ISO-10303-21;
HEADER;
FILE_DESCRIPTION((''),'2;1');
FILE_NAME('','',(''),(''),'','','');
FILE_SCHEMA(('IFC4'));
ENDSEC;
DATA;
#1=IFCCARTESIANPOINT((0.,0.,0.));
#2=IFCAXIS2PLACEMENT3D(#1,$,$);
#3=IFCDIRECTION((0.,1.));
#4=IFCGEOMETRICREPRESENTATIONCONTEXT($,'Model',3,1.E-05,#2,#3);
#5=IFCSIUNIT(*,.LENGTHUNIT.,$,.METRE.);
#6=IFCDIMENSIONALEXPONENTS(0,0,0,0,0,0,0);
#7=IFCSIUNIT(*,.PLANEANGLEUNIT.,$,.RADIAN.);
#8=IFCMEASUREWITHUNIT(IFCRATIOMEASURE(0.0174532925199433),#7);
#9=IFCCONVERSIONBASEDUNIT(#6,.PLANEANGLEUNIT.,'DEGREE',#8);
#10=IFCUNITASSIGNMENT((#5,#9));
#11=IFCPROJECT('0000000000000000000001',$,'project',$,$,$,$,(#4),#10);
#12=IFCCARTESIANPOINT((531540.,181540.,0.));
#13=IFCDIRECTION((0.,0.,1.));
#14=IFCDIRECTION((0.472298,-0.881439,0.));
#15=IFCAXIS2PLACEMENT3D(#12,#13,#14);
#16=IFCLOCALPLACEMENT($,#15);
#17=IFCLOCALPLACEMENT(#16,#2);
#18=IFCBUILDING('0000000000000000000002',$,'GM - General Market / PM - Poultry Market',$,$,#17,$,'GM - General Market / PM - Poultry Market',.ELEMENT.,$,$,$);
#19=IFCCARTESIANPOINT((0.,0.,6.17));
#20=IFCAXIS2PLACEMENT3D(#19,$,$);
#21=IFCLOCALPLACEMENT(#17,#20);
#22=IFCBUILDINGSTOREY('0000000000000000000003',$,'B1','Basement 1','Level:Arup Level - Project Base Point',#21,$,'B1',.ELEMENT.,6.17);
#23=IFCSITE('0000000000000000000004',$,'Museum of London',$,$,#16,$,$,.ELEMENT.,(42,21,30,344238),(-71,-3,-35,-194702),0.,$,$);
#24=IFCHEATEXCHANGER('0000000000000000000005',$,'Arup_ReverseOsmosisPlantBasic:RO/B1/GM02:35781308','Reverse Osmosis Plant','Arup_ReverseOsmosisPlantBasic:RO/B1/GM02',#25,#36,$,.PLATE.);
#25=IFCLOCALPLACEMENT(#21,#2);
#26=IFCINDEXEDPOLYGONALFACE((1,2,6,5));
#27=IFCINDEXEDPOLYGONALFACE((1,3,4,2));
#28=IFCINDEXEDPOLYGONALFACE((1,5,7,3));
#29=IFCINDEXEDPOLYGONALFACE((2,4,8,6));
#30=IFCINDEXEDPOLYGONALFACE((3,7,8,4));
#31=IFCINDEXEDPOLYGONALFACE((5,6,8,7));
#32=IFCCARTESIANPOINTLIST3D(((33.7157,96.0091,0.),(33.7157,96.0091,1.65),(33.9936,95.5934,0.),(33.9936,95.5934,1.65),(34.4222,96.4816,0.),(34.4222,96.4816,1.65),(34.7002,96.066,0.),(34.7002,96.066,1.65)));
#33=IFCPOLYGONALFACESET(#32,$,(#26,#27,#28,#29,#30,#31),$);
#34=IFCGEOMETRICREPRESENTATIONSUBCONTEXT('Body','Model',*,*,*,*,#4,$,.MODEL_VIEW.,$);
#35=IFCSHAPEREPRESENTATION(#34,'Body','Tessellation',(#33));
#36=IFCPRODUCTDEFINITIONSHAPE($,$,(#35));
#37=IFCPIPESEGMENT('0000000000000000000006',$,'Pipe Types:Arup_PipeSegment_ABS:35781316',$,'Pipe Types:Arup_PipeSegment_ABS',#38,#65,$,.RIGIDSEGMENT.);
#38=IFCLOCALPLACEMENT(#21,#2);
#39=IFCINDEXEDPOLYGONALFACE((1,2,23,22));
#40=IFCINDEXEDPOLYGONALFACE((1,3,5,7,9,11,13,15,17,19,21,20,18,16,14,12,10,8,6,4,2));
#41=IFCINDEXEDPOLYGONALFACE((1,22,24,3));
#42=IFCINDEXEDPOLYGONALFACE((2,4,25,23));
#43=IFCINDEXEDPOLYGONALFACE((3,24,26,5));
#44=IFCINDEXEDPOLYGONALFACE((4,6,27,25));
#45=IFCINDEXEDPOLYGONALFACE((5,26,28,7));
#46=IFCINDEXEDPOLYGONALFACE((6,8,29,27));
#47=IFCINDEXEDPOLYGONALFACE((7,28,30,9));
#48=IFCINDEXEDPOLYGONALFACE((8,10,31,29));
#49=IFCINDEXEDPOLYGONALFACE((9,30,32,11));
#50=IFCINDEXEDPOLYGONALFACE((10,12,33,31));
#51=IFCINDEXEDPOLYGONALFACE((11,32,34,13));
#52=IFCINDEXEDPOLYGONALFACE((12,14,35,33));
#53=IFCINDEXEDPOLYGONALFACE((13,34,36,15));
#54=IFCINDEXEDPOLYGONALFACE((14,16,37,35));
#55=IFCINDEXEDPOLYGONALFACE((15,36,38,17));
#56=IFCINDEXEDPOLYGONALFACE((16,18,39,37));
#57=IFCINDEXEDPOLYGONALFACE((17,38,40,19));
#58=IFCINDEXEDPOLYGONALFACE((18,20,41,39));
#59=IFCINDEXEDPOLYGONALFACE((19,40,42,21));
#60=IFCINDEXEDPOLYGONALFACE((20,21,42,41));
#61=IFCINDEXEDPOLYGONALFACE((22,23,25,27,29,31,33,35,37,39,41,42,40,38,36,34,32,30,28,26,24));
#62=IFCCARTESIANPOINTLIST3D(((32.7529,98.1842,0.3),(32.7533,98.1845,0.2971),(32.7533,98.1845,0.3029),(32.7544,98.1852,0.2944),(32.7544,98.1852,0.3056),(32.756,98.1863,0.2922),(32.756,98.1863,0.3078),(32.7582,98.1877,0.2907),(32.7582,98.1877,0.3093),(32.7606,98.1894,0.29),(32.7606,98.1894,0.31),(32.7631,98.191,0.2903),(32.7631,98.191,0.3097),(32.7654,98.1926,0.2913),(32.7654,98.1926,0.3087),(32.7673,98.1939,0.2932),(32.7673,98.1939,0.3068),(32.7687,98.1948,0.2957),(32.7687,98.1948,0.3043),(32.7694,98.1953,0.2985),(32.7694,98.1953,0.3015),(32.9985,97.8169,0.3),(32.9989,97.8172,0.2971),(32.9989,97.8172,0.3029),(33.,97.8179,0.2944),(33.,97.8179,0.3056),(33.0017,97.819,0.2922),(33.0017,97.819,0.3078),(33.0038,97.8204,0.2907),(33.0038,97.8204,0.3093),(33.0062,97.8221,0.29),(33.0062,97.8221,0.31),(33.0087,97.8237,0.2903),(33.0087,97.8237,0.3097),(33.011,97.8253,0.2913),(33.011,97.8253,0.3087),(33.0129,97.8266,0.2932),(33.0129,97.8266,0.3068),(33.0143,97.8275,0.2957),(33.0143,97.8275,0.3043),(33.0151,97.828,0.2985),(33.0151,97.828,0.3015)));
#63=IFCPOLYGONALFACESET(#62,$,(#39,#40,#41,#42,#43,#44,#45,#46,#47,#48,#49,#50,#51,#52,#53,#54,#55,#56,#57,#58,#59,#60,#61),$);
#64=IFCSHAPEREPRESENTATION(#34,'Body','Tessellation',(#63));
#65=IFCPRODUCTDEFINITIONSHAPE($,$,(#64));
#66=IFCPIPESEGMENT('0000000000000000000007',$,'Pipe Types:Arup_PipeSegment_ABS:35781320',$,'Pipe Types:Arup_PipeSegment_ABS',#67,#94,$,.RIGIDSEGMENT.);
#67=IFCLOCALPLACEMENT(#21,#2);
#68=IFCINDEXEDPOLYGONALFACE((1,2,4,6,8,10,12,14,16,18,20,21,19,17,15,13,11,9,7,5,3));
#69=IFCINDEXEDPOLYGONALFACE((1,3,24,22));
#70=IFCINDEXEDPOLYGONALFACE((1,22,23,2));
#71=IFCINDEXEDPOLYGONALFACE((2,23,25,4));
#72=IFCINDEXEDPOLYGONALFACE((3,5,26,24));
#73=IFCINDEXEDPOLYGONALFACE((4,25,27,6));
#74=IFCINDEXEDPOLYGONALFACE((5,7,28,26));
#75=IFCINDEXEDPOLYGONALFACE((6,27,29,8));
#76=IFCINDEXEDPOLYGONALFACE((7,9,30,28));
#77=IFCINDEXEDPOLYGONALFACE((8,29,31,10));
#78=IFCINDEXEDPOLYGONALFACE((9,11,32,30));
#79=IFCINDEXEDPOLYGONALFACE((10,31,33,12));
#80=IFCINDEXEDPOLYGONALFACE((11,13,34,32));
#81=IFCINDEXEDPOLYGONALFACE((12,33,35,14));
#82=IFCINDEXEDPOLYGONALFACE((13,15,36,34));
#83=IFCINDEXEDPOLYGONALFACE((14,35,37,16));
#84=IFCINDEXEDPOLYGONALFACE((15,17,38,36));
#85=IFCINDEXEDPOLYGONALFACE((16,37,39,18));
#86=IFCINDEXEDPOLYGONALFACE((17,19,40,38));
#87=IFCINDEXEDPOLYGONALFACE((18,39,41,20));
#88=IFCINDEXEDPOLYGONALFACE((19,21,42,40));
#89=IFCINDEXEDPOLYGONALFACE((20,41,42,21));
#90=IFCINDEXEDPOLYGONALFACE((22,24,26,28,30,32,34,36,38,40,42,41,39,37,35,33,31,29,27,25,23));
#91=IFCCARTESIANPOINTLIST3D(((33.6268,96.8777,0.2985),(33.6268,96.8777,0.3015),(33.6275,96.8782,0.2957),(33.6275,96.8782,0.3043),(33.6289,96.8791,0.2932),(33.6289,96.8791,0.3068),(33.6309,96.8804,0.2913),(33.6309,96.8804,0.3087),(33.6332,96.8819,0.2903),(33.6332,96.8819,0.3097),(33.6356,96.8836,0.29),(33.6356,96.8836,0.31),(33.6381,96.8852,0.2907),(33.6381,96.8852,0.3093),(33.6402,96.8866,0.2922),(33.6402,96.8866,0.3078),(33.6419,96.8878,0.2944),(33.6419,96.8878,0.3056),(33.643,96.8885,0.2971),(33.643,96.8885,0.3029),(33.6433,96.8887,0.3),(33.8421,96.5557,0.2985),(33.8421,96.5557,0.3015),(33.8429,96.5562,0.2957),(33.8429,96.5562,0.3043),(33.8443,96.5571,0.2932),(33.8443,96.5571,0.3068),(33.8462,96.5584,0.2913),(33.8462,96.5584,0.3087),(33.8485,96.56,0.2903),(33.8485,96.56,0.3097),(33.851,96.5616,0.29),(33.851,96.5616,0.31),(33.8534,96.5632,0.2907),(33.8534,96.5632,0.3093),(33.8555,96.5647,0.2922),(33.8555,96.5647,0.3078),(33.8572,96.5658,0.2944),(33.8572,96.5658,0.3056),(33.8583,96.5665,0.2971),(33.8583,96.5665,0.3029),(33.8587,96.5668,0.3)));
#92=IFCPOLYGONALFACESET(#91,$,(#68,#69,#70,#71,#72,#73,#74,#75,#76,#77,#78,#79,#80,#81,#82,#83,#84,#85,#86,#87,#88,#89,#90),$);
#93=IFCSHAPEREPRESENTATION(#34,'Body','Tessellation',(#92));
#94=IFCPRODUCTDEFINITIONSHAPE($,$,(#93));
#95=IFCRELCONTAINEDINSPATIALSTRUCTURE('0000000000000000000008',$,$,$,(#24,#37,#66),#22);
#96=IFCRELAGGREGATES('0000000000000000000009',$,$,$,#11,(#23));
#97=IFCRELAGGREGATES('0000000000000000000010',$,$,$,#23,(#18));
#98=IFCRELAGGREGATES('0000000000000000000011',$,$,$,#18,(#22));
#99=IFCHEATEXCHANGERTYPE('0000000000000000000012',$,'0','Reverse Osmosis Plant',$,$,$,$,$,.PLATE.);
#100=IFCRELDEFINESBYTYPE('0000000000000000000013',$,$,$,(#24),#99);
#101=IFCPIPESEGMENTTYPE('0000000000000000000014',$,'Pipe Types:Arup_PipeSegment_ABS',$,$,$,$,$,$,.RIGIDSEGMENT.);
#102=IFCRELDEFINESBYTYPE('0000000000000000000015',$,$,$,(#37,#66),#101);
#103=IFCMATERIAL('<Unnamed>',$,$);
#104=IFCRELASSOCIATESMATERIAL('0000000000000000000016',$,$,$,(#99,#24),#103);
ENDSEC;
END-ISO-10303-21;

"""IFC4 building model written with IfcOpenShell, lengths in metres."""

from ifc_helpers import new_model, entity, si_unit, converted_unit, direction, frame, origin, origin_2d_with_axis, place, context, subcontext, project, spatial, rectangle, circle, extrude, source, transform, mapped, material, type_object, type_shapes, element, save


model = new_model("IFC4")

# Units and contexts
model_context = context("Model", 3, precision=1e-05, world=origin(), true_north=direction((0.0, 1.0)))
body_context = subcontext(model_context, "Body", "Model", "MODEL_VIEW")
ifc_project = project(units=[si_unit("LENGTHUNIT", "METRE"), converted_unit("PLANEANGLEUNIT", "DEGREE", entity("IfcRatioMeasure", 0.0174532925199433), si_unit("PLANEANGLEUNIT", "RADIAN"), dimensions=[0, 0, 0, 0, 0, 0, 0])], contexts=[model_context])

# Site, building, storey
site_placement = place(None, frame((531540.0, 181540.0, 0.0), z_axis=(0.0, 0.0, 1.0), x_axis=(0.472298, -0.881439, 0.0)))
site = spatial("IfcSite", under=ifc_project, at=site_placement, Name="Museum of London", CompositionType="ELEMENT", RefLatitude=(42, 21, 30, 344238), RefLongitude=(-71, -3, -35, -194702), RefElevation=0.0)
building_placement = place(site_placement, origin())
building = spatial("IfcBuilding", under=site, at=building_placement, Name="GM - General Market / PM - Poultry Market", LongName="GM - General Market / PM - Poultry Market", CompositionType="ELEMENT")
storey_placement = place(building_placement, frame((0.0, 0.0, 6.17)))
storey = spatial("IfcBuildingStorey", under=building, at=storey_placement, Name="B1", Description="Basement 1", ObjectType="Level:Arup Level - Project Base Point", LongName="B1", CompositionType="ELEMENT", Elevation=6.17)

# Shared definitions
ifc_material_1 = material(Name="<Unnamed>")

# Heat exchanger
heat_exchanger_type = type_object("IfcHeatExchangerType", Name="0", Description="Reverse Osmosis Plant", PredefinedType="PLATE", material=ifc_material_1)
shared_shape_1 = source(origin(), body_context, "Body", "SweptSolid", [
    extrude(rectangle(XDim=0.85, YDim=0.5, at=origin_2d_with_axis()), frame((0.0, 0.0, 0.0), z_axis=(0.0, 0.0, 1.0), x_axis=(-1.0, 0.0, 0.0)), (0.0, 0.0, 1.0), 1.65),
])
type_shapes(heat_exchanger_type, [shared_shape_1])
heat_exchanger_placement = place(storey_placement, frame((34.2079, 96.0375, 0.0), z_axis=(0.0, 0.0, 1.0), x_axis=(-0.831246, -0.555905, 0.0)))
element("IfcHeatExchanger", 1, at=heat_exchanger_placement, inside=storey, type_object=heat_exchanger_type, material=ifc_material_1, Name="Arup_ReverseOsmosisPlantBasic:RO/B1/GM02:35781308", Description="Reverse Osmosis Plant", ObjectType="Arup_ReverseOsmosisPlantBasic:RO/B1/GM02", PredefinedType="PLATE", context=body_context, shape_type="MappedRepresentation", body=[
    mapped(shared_shape_1, transform((0.0, 0.0, 0.0), scale=1.0)),
])

# Pipe segments
pipe_segment_type_1 = type_object("IfcPipeSegmentType", Name="Pipe Types:Arup_PipeSegment_ABS", PredefinedType="RIGIDSEGMENT")
pipe_segment_1_placement = place(storey_placement, frame((32.7513, 97.8153, 0.2884)))
element("IfcPipeSegment", 2, at=pipe_segment_1_placement, inside=storey, type_object=pipe_segment_type_1, Name="Pipe Types:Arup_PipeSegment_ABS:35781316", ObjectType="Pipe Types:Arup_PipeSegment_ABS", PredefinedType="RIGIDSEGMENT", context=body_context, shape_type="SweptSolid", body=[
    extrude(circle(Radius=0.01, at=origin_2d_with_axis()), frame((0.0099, 0.3745, 0.0116), z_axis=(0.555905, -0.831246, 0.0), x_axis=(-0.831246, -0.555905, 0.0)), (0.0, 0.0, 1.0), 0.4419),
])
pipe_segment_2_placement = place(storey_placement, frame((33.6251, 96.554, 0.2884)))
element("IfcPipeSegment", 3, at=pipe_segment_2_placement, inside=storey, type_object=pipe_segment_type_1, Name="Pipe Types:Arup_PipeSegment_ABS:35781320", ObjectType="Pipe Types:Arup_PipeSegment_ABS", PredefinedType="RIGIDSEGMENT", context=body_context, shape_type="SweptSolid", body=[
    extrude(circle(Radius=0.01, at=origin_2d_with_axis()), frame((0.2252, 0.0072, 0.0116), z_axis=(-0.555905, 0.831246, 0.0), x_axis=(0.831246, 0.555905, 0.0)), (0.0, 0.0, 1.0), 0.3873),
])

save(model, "model.ifc")
